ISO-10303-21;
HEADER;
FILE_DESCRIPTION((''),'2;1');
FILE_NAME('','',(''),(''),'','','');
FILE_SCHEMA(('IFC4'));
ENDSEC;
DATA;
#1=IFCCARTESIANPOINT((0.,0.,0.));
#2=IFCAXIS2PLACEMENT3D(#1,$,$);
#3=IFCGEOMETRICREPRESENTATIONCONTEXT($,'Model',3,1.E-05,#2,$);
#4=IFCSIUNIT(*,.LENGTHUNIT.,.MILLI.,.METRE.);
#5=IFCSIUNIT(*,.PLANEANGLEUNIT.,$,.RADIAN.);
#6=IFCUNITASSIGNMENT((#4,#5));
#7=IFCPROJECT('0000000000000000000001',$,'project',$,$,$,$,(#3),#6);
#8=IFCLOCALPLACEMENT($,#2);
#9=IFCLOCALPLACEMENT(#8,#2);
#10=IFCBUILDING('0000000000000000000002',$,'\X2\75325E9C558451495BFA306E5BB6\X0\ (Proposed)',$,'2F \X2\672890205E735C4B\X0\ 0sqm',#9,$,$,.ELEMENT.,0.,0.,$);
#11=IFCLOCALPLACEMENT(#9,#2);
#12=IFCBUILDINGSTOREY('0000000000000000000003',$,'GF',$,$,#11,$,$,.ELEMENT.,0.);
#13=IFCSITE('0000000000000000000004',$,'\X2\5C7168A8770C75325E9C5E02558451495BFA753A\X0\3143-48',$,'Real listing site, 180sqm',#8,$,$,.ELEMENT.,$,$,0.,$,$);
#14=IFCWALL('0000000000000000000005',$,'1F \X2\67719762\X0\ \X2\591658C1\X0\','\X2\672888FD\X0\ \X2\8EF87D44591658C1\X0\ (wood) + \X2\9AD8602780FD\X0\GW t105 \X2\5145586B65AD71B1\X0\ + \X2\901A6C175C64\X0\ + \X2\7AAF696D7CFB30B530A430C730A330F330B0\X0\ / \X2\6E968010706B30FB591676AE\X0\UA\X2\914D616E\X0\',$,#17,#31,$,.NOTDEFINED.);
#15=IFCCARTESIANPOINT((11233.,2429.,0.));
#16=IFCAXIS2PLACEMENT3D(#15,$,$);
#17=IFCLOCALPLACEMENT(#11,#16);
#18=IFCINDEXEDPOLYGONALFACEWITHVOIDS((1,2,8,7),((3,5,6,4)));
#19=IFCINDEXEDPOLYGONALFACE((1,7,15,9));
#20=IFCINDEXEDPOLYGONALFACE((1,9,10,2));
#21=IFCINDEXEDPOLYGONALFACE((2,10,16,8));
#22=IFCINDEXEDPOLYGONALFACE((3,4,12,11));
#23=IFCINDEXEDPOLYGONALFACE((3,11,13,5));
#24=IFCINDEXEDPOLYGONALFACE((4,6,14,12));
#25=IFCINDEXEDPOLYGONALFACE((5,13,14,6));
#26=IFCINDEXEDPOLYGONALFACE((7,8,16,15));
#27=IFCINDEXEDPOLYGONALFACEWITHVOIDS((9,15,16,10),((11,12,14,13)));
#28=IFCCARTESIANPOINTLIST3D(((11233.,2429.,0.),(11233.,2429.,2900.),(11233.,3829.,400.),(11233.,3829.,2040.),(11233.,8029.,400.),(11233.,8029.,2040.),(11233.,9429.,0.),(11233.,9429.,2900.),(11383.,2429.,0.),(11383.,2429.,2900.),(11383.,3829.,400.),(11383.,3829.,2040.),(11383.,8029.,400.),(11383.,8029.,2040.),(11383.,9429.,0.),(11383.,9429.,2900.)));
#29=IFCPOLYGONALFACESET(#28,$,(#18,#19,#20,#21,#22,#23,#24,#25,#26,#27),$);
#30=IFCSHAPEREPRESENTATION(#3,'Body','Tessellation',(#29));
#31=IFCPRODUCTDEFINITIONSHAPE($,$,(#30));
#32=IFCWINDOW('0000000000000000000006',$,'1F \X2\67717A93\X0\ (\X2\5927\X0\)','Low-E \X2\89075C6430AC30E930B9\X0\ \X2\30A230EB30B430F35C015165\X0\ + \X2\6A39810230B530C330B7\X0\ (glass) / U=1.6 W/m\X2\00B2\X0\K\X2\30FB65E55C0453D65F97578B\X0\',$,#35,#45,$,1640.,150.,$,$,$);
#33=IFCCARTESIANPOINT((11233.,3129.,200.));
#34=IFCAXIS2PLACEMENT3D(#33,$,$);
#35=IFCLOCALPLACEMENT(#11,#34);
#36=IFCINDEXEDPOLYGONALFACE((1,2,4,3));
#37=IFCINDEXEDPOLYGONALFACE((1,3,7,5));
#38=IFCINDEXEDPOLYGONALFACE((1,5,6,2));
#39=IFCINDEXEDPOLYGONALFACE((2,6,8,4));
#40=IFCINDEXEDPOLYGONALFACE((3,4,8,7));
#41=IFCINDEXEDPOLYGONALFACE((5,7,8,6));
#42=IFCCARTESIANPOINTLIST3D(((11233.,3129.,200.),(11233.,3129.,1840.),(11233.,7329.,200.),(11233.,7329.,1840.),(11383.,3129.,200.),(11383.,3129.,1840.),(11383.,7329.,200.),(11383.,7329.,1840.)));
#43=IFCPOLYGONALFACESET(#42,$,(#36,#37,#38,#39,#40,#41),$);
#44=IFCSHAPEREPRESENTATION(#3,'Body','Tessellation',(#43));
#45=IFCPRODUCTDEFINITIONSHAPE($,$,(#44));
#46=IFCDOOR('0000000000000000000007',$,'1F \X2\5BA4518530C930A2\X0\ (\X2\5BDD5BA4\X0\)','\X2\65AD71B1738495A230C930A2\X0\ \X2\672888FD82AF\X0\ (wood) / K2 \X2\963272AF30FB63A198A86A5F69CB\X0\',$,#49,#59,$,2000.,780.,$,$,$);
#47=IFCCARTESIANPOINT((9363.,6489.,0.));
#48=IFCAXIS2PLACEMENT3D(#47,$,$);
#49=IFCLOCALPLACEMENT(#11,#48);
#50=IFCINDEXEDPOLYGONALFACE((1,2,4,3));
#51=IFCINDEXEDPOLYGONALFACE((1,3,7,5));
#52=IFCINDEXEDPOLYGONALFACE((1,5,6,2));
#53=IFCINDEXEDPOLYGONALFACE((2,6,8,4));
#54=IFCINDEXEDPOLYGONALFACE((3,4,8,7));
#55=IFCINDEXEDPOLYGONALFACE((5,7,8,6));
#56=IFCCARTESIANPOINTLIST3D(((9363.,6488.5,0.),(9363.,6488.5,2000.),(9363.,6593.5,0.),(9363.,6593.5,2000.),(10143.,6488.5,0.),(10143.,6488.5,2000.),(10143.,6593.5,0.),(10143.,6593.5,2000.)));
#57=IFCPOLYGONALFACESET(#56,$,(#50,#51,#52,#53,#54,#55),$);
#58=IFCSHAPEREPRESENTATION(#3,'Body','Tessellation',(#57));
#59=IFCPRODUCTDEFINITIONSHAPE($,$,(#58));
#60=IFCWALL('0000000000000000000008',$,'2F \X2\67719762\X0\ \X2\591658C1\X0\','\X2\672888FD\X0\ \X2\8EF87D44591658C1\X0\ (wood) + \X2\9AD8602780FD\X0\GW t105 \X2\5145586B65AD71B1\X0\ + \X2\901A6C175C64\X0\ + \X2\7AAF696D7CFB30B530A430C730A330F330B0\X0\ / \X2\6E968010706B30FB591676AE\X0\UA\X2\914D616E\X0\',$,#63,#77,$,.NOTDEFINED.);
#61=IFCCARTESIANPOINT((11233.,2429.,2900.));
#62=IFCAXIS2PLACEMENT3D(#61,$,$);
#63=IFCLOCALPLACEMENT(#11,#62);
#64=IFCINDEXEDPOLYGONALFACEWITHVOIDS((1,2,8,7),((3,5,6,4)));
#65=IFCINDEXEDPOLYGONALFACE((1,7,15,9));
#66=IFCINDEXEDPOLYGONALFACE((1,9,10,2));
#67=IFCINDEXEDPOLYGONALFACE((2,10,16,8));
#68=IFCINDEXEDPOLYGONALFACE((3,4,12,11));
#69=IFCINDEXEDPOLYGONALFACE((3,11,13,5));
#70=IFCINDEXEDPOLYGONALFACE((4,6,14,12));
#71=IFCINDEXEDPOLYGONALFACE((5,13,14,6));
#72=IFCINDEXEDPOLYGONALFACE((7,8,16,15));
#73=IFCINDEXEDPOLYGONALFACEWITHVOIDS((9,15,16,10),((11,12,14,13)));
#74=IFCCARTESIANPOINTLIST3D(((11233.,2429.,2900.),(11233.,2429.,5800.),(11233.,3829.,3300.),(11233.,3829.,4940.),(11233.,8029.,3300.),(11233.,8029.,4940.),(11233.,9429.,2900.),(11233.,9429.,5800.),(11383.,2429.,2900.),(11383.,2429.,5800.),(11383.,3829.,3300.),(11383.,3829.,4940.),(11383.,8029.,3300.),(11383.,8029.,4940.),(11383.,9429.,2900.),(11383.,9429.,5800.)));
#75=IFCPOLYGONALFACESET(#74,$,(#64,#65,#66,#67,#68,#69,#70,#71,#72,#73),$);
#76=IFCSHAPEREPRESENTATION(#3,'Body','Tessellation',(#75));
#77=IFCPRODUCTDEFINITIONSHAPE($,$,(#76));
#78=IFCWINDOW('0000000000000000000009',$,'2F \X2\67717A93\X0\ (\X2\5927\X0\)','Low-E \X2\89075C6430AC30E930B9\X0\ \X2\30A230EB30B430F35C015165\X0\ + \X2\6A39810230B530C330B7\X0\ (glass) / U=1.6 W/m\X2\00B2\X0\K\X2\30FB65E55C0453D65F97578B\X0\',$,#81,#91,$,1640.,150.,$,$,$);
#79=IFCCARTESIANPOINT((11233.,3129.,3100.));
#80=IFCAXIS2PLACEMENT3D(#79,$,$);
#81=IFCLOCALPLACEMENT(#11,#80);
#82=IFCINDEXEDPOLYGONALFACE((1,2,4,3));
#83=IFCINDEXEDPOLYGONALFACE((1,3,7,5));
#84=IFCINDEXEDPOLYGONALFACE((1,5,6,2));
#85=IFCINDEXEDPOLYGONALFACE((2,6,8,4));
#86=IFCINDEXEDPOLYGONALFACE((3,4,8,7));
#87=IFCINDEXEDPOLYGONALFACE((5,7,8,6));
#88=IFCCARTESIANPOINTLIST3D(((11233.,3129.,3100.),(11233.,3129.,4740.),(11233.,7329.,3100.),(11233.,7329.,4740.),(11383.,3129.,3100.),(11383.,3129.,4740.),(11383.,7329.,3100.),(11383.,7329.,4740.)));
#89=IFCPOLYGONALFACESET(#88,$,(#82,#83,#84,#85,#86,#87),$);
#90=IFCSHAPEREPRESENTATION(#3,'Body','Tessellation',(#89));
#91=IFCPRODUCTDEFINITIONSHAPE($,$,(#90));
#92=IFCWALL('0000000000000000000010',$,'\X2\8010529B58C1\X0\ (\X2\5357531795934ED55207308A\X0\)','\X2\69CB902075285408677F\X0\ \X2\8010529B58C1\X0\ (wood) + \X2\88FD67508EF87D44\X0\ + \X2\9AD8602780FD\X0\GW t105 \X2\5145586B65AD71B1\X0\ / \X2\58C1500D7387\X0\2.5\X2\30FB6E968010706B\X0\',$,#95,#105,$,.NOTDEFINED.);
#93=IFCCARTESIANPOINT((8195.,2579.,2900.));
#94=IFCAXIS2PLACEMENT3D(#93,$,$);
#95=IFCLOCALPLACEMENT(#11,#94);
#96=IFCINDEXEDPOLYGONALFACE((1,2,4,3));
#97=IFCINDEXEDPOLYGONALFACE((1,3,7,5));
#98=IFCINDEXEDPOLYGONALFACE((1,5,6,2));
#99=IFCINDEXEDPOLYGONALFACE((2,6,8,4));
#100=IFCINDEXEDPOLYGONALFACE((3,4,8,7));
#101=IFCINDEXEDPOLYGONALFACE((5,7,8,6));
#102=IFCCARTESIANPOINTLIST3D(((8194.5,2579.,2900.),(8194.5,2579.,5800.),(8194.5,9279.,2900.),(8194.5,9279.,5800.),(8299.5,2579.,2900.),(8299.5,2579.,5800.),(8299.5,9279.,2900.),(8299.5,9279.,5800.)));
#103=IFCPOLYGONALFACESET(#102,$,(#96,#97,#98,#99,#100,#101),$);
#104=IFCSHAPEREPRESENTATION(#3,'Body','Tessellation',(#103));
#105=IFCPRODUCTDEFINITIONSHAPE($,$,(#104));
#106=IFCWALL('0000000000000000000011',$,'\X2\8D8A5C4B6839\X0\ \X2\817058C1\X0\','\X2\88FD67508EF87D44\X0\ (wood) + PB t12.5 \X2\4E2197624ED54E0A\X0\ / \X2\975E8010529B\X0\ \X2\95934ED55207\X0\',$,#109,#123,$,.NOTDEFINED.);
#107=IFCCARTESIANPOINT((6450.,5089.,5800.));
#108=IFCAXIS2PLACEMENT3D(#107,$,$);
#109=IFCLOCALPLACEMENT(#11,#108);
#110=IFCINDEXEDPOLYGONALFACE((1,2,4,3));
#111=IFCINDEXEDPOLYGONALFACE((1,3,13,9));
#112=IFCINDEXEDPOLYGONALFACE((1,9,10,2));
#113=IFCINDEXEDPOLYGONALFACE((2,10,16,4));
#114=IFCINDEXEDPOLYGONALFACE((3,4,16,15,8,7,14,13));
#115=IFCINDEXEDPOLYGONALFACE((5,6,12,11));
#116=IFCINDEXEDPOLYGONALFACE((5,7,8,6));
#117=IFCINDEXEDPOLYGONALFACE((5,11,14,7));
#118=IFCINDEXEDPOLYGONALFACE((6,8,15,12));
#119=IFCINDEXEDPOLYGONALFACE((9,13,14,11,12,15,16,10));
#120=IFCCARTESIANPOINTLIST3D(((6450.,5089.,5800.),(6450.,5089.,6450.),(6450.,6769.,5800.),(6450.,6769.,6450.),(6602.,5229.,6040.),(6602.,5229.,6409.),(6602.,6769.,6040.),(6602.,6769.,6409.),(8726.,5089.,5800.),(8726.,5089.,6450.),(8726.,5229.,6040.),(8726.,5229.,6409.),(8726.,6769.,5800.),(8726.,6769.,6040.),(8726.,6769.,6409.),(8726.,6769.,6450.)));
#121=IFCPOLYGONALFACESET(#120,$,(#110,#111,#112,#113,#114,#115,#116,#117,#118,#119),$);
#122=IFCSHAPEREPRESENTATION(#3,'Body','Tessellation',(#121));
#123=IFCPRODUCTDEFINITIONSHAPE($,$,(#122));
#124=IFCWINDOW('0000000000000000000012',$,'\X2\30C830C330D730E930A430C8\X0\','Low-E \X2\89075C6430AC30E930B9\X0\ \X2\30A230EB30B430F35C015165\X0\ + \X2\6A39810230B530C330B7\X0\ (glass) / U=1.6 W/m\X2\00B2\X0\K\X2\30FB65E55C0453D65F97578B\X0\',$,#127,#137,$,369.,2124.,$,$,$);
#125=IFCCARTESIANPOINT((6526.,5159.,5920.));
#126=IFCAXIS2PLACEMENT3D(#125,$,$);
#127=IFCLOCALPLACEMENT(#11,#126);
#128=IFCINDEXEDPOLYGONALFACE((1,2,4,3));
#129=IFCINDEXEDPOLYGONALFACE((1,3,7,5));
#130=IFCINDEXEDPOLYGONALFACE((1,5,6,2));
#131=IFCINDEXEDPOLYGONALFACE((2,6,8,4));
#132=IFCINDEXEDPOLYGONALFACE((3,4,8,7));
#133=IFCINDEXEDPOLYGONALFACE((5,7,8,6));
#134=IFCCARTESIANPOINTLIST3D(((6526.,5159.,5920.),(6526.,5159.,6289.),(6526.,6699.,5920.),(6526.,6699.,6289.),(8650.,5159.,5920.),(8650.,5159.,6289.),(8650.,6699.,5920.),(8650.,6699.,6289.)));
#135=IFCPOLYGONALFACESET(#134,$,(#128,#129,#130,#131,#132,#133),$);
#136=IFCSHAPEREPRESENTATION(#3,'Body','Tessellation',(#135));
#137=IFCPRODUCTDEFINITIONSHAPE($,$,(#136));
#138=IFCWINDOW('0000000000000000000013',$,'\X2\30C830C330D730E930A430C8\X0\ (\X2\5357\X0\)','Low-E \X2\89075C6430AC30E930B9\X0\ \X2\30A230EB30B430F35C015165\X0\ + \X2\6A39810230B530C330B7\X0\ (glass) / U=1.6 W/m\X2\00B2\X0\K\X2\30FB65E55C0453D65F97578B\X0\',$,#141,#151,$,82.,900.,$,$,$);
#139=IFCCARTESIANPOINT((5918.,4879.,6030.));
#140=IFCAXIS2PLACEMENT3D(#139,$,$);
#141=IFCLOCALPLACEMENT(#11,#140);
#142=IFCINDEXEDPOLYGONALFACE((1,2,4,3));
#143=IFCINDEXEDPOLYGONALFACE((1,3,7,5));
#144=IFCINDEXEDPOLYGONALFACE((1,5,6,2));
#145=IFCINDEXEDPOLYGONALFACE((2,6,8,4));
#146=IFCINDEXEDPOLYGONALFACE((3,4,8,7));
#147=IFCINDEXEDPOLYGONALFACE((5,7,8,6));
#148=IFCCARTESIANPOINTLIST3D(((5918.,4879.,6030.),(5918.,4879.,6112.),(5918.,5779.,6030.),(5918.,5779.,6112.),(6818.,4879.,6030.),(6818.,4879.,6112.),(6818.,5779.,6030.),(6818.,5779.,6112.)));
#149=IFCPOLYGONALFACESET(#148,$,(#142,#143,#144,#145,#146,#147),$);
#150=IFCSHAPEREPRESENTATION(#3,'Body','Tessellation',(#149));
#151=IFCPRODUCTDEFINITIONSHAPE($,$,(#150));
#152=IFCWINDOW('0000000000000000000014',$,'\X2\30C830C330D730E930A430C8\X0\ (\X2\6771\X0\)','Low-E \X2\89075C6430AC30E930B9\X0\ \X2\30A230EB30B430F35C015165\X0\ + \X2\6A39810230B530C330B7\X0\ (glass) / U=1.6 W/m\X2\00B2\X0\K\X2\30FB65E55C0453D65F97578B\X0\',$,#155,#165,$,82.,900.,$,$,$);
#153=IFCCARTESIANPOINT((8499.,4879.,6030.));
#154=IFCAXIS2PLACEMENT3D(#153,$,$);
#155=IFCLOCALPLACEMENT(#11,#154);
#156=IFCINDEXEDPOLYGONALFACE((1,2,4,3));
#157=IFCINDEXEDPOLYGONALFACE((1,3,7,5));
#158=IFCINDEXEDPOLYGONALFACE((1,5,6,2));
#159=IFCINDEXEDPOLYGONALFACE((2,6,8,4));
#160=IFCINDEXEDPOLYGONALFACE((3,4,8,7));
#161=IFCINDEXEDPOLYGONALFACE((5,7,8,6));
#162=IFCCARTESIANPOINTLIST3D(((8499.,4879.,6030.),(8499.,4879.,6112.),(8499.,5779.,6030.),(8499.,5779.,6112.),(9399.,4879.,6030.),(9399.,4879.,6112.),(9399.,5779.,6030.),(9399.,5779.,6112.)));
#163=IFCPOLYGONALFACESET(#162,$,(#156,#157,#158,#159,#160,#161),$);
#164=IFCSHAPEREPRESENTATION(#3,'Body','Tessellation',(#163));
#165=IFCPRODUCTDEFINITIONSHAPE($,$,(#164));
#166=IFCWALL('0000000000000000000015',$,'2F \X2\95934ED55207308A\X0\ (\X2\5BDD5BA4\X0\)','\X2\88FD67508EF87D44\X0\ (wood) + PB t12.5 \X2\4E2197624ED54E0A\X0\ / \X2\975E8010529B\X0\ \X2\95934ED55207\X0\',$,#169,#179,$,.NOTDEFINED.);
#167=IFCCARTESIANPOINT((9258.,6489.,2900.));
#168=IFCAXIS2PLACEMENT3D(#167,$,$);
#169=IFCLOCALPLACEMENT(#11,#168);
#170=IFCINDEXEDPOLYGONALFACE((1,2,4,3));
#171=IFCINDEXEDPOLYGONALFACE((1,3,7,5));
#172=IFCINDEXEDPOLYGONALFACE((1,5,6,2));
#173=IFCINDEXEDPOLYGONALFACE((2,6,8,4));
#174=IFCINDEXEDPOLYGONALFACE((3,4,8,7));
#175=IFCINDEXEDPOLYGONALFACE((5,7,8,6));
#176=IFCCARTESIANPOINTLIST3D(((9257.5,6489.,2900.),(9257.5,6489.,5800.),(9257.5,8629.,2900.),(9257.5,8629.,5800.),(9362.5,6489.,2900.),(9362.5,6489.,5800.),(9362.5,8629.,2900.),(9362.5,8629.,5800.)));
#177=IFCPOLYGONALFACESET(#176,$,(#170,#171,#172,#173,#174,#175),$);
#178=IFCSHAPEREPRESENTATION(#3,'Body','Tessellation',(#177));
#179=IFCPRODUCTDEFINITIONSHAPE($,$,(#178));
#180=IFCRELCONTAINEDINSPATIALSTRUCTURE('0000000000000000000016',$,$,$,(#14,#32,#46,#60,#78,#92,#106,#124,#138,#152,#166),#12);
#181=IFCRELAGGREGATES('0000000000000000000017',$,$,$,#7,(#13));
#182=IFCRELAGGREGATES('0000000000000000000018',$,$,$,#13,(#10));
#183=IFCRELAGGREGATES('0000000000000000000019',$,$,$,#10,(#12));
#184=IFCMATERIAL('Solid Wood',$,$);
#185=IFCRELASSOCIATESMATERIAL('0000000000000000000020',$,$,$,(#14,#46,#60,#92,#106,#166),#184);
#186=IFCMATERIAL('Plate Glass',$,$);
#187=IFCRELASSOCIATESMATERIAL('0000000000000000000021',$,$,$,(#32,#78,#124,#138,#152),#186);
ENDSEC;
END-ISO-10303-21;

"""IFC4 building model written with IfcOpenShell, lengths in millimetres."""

from ifc_helpers import new_model, si_unit, frame, frame_2d, origin, place, context, project, spatial, rectangle, extrude, material, element, fill, save


model = new_model("IFC4")

# Units and contexts
model_context = context("Model", 3, precision=1e-05, world=origin())
ifc_project = project(units=[si_unit("LENGTHUNIT", "METRE", prefix="MILLI"), si_unit("PLANEANGLEUNIT", "RADIAN")], contexts=[model_context])

# Site, building, storey
site_placement = place(None, origin())
site = spatial("IfcSite", under=ifc_project, at=site_placement, Name="山梨県甲府市善光寺町3143-48", ObjectType="Real listing site, 180sqm", CompositionType="ELEMENT", RefElevation=0.0)
building_placement = place(site_placement, origin())
building = spatial("IfcBuilding", under=site, at=building_placement, Name="甲府善光寺の家 (Proposed)", ObjectType="2F 木造平屋 0sqm", CompositionType="ELEMENT", ElevationOfRefHeight=0.0, ElevationOfTerrain=0.0)
storey_placement = place(building_placement, origin())
storey = spatial("IfcBuildingStorey", under=building, at=storey_placement, Name="GF", CompositionType="ELEMENT", Elevation=0.0)

# Wall, opening, window
ifc_material_1 = material(Name="Solid Wood")
wall_1_placement = place(storey_placement, frame((11233.0, 2429.0, 0.0)))
wall_1 = element("IfcWall", 1, at=wall_1_placement, inside=storey, material=ifc_material_1, Name="1F 東面 外壁", Description="木製 軸組外壁 (wood) + 高性能GW t105 充填断熱 + 通気層 + 窯業系サイディング / 準耐火・外皮UA配慮", PredefinedType="NOTDEFINED", context=model_context, shape_type="SweptSolid", body=[
    extrude(rectangle(XDim=150.0, YDim=7000.0, at=frame_2d((75.0, 3500.0))), frame((11233.0, 2429.0, 0.0)), (0.0, 0.0, 1.0), 2900.0),
])
opening_1_placement = place(storey_placement, frame((11233.0, 3129.0, 200.0)))
opening_1 = element("IfcOpeningElement", 2, at=opening_1_placement, cuts=wall_1, PredefinedType="NOTDEFINED", context=model_context, shape_type="SweptSolid", body=[
    extrude(rectangle(XDim=150.0, YDim=4200.0, at=frame_2d((75.0, 2100.0))), frame((11233.0, 3129.0, 200.0)), (0.0, 0.0, 1.0), 1640.0),
])
ifc_material_2 = material(Name="Plate Glass")
window_1_placement = place(storey_placement, frame((11233.0, 3129.0, 200.0)))
window_1 = element("IfcWindow", 3, at=window_1_placement, inside=storey, material=ifc_material_2, Name="1F 東窓 (大)", Description="Low-E 複層ガラス アルゴン封入 + 樹脂サッシ (glass) / U=1.6 W/m²K・日射取得型", OverallHeight=1640.0, OverallWidth=150.0, context=model_context, shape_type="SweptSolid", body=[
    extrude(rectangle(XDim=150.0, YDim=4200.0, at=frame_2d((75.0, 2100.0))), frame((11233.0, 3129.0, 200.0)), (0.0, 0.0, 1.0), 1640.0),
])
fill(opening_1, window_1)

# Door
door_1_placement = place(storey_placement, frame((9363.0, 6489.0, 0.0)))
element("IfcDoor", 4, at=door_1_placement, inside=storey, material=ifc_material_1, Name="1F 室内ドア (寝室)", Description="断熱玄関ドア 木製芯 (wood) / K2 防犯・採風機構", OverallHeight=2000.0, OverallWidth=780.0, context=model_context, shape_type="SweptSolid", body=[
    extrude(rectangle(XDim=780.0, YDim=105.0, at=frame_2d((390.0, 52.0))), frame((9363.0, 6489.0, 0.0)), (0.0, 0.0, 1.0), 2000.0),
])

# Wall, opening, window
wall_2_placement = place(storey_placement, frame((11233.0, 2429.0, 2900.0)))
wall_2 = element("IfcWall", 5, at=wall_2_placement, inside=storey, material=ifc_material_1, Name="2F 東面 外壁", Description="木製 軸組外壁 (wood) + 高性能GW t105 充填断熱 + 通気層 + 窯業系サイディング / 準耐火・外皮UA配慮", PredefinedType="NOTDEFINED", context=model_context, shape_type="SweptSolid", body=[
    extrude(rectangle(XDim=150.0, YDim=7000.0, at=frame_2d((75.0, 3500.0))), frame((11233.0, 2429.0, 2900.0)), (0.0, 0.0, 1.0), 2900.0),
])
opening_2_placement = place(storey_placement, frame((11233.0, 3129.0, 3100.0)))
opening_2 = element("IfcOpeningElement", 6, at=opening_2_placement, cuts=wall_2, PredefinedType="NOTDEFINED", context=model_context, shape_type="SweptSolid", body=[
    extrude(rectangle(XDim=150.0, YDim=4200.0, at=frame_2d((75.0, 2100.0))), frame((11233.0, 3129.0, 3100.0)), (0.0, 0.0, 1.0), 1640.0),
])
window_2_placement = place(storey_placement, frame((11233.0, 3129.0, 3100.0)))
window_2 = element("IfcWindow", 7, at=window_2_placement, inside=storey, material=ifc_material_2, Name="2F 東窓 (大)", Description="Low-E 複層ガラス アルゴン封入 + 樹脂サッシ (glass) / U=1.6 W/m²K・日射取得型", OverallHeight=1640.0, OverallWidth=150.0, context=model_context, shape_type="SweptSolid", body=[
    extrude(rectangle(XDim=150.0, YDim=4200.0, at=frame_2d((75.0, 2100.0))), frame((11233.0, 3129.0, 3100.0)), (0.0, 0.0, 1.0), 1640.0),
])
fill(opening_2, window_2)

# Wall
wall_3_placement = place(storey_placement, frame((8195.0, 2579.0, 2900.0)))
element("IfcWall", 8, at=wall_3_placement, inside=storey, material=ifc_material_1, Name="耐力壁 (南北間仕切り)", Description="構造用合板 耐力壁 (wood) + 製材軸組 + 高性能GW t105 充填断熱 / 壁倍率2.5・準耐火", PredefinedType="NOTDEFINED", context=model_context, shape_type="SweptSolid", body=[
    extrude(rectangle(XDim=105.0, YDim=6700.0, at=frame_2d((52.0, 3350.0))), frame((8195.0, 2579.0, 2900.0)), (0.0, 0.0, 1.0), 2900.0),
])

# Wall, openings, windows
wall_4_placement = place(storey_placement, frame((6450.0, 5089.0, 5800.0)))
wall_4 = element("IfcWall", 9, at=wall_4_placement, inside=storey, material=ifc_material_1, Name="越屋根 腰壁", Description="製材軸組 (wood) + PB t12.5 両面仕上 / 非耐力 間仕切", PredefinedType="NOTDEFINED", context=model_context, shape_type="SweptSolid", body=[
    extrude(rectangle(XDim=2276.0, YDim=1680.0, at=frame_2d((1138.0, 840.0))), frame((6450.0, 5089.0, 5800.0)), (0.0, 0.0, 1.0), 650.0),
])
opening_3_placement = place(storey_placement, frame((6526.0, 5159.0, 5920.0)))
opening_3 = element("IfcOpeningElement", 10, at=opening_3_placement, cuts=wall_4, PredefinedType="NOTDEFINED", context=model_context, shape_type="SweptSolid", body=[
    extrude(rectangle(XDim=2124.0, YDim=1540.0, at=frame_2d((1062.0, 770.0))), frame((6526.0, 5159.0, 5920.0)), (0.0, 0.0, 1.0), 369.0),
])
opening_4_placement = place(storey_placement, frame((5918.0, 4879.0, 6030.0)))
opening_4 = element("IfcOpeningElement", 11, at=opening_4_placement, cuts=wall_4, PredefinedType="NOTDEFINED", context=model_context, shape_type="SweptSolid", body=[
    extrude(rectangle(XDim=900.0, YDim=900.0, at=frame_2d((450.0, 450.0))), frame((5918.0, 4879.0, 6030.0)), (0.0, 0.0, 1.0), 82.0),
])
opening_5_placement = place(storey_placement, frame((8499.0, 4879.0, 6030.0)))
opening_5 = element("IfcOpeningElement", 12, at=opening_5_placement, cuts=wall_4, PredefinedType="NOTDEFINED", context=model_context, shape_type="SweptSolid", body=[
    extrude(rectangle(XDim=900.0, YDim=900.0, at=frame_2d((450.0, 450.0))), frame((8499.0, 4879.0, 6030.0)), (0.0, 0.0, 1.0), 82.0),
])
window_3_placement = place(storey_placement, frame((6526.0, 5159.0, 5920.0)))
window_3 = element("IfcWindow", 13, at=window_3_placement, inside=storey, material=ifc_material_2, Name="トップライト", Description="Low-E 複層ガラス アルゴン封入 + 樹脂サッシ (glass) / U=1.6 W/m²K・日射取得型", OverallHeight=369.0, OverallWidth=2124.0, context=model_context, shape_type="SweptSolid", body=[
    extrude(rectangle(XDim=2124.0, YDim=1540.0, at=frame_2d((1062.0, 770.0))), frame((6526.0, 5159.0, 5920.0)), (0.0, 0.0, 1.0), 369.0),
])
fill(opening_3, window_3)
window_4_placement = place(storey_placement, frame((5918.0, 4879.0, 6030.0)))
window_4 = element("IfcWindow", 14, at=window_4_placement, inside=storey, material=ifc_material_2, Name="トップライト (南)", Description="Low-E 複層ガラス アルゴン封入 + 樹脂サッシ (glass) / U=1.6 W/m²K・日射取得型", OverallHeight=82.0, OverallWidth=900.0, context=model_context, shape_type="SweptSolid", body=[
    extrude(rectangle(XDim=900.0, YDim=900.0, at=frame_2d((450.0, 450.0))), frame((5918.0, 4879.0, 6030.0)), (0.0, 0.0, 1.0), 82.0),
])
fill(opening_4, window_4)
window_5_placement = place(storey_placement, frame((8499.0, 4879.0, 6030.0)))
window_5 = element("IfcWindow", 15, at=window_5_placement, inside=storey, material=ifc_material_2, Name="トップライト (東)", Description="Low-E 複層ガラス アルゴン封入 + 樹脂サッシ (glass) / U=1.6 W/m²K・日射取得型", OverallHeight=82.0, OverallWidth=900.0, context=model_context, shape_type="SweptSolid", body=[
    extrude(rectangle(XDim=900.0, YDim=900.0, at=frame_2d((450.0, 450.0))), frame((8499.0, 4879.0, 6030.0)), (0.0, 0.0, 1.0), 82.0),
])
fill(opening_5, window_5)

# Wall
wall_5_placement = place(storey_placement, frame((9258.0, 6489.0, 2900.0)))
element("IfcWall", 16, at=wall_5_placement, inside=storey, material=ifc_material_1, Name="2F 間仕切り (寝室)", Description="製材軸組 (wood) + PB t12.5 両面仕上 / 非耐力 間仕切", PredefinedType="NOTDEFINED", context=model_context, shape_type="SweptSolid", body=[
    extrude(rectangle(XDim=105.0, YDim=2140.0, at=frame_2d((52.0, 1070.0))), frame((9258.0, 6489.0, 2900.0)), (0.0, 0.0, 1.0), 2900.0),
])

save(model, "model.ifc")
